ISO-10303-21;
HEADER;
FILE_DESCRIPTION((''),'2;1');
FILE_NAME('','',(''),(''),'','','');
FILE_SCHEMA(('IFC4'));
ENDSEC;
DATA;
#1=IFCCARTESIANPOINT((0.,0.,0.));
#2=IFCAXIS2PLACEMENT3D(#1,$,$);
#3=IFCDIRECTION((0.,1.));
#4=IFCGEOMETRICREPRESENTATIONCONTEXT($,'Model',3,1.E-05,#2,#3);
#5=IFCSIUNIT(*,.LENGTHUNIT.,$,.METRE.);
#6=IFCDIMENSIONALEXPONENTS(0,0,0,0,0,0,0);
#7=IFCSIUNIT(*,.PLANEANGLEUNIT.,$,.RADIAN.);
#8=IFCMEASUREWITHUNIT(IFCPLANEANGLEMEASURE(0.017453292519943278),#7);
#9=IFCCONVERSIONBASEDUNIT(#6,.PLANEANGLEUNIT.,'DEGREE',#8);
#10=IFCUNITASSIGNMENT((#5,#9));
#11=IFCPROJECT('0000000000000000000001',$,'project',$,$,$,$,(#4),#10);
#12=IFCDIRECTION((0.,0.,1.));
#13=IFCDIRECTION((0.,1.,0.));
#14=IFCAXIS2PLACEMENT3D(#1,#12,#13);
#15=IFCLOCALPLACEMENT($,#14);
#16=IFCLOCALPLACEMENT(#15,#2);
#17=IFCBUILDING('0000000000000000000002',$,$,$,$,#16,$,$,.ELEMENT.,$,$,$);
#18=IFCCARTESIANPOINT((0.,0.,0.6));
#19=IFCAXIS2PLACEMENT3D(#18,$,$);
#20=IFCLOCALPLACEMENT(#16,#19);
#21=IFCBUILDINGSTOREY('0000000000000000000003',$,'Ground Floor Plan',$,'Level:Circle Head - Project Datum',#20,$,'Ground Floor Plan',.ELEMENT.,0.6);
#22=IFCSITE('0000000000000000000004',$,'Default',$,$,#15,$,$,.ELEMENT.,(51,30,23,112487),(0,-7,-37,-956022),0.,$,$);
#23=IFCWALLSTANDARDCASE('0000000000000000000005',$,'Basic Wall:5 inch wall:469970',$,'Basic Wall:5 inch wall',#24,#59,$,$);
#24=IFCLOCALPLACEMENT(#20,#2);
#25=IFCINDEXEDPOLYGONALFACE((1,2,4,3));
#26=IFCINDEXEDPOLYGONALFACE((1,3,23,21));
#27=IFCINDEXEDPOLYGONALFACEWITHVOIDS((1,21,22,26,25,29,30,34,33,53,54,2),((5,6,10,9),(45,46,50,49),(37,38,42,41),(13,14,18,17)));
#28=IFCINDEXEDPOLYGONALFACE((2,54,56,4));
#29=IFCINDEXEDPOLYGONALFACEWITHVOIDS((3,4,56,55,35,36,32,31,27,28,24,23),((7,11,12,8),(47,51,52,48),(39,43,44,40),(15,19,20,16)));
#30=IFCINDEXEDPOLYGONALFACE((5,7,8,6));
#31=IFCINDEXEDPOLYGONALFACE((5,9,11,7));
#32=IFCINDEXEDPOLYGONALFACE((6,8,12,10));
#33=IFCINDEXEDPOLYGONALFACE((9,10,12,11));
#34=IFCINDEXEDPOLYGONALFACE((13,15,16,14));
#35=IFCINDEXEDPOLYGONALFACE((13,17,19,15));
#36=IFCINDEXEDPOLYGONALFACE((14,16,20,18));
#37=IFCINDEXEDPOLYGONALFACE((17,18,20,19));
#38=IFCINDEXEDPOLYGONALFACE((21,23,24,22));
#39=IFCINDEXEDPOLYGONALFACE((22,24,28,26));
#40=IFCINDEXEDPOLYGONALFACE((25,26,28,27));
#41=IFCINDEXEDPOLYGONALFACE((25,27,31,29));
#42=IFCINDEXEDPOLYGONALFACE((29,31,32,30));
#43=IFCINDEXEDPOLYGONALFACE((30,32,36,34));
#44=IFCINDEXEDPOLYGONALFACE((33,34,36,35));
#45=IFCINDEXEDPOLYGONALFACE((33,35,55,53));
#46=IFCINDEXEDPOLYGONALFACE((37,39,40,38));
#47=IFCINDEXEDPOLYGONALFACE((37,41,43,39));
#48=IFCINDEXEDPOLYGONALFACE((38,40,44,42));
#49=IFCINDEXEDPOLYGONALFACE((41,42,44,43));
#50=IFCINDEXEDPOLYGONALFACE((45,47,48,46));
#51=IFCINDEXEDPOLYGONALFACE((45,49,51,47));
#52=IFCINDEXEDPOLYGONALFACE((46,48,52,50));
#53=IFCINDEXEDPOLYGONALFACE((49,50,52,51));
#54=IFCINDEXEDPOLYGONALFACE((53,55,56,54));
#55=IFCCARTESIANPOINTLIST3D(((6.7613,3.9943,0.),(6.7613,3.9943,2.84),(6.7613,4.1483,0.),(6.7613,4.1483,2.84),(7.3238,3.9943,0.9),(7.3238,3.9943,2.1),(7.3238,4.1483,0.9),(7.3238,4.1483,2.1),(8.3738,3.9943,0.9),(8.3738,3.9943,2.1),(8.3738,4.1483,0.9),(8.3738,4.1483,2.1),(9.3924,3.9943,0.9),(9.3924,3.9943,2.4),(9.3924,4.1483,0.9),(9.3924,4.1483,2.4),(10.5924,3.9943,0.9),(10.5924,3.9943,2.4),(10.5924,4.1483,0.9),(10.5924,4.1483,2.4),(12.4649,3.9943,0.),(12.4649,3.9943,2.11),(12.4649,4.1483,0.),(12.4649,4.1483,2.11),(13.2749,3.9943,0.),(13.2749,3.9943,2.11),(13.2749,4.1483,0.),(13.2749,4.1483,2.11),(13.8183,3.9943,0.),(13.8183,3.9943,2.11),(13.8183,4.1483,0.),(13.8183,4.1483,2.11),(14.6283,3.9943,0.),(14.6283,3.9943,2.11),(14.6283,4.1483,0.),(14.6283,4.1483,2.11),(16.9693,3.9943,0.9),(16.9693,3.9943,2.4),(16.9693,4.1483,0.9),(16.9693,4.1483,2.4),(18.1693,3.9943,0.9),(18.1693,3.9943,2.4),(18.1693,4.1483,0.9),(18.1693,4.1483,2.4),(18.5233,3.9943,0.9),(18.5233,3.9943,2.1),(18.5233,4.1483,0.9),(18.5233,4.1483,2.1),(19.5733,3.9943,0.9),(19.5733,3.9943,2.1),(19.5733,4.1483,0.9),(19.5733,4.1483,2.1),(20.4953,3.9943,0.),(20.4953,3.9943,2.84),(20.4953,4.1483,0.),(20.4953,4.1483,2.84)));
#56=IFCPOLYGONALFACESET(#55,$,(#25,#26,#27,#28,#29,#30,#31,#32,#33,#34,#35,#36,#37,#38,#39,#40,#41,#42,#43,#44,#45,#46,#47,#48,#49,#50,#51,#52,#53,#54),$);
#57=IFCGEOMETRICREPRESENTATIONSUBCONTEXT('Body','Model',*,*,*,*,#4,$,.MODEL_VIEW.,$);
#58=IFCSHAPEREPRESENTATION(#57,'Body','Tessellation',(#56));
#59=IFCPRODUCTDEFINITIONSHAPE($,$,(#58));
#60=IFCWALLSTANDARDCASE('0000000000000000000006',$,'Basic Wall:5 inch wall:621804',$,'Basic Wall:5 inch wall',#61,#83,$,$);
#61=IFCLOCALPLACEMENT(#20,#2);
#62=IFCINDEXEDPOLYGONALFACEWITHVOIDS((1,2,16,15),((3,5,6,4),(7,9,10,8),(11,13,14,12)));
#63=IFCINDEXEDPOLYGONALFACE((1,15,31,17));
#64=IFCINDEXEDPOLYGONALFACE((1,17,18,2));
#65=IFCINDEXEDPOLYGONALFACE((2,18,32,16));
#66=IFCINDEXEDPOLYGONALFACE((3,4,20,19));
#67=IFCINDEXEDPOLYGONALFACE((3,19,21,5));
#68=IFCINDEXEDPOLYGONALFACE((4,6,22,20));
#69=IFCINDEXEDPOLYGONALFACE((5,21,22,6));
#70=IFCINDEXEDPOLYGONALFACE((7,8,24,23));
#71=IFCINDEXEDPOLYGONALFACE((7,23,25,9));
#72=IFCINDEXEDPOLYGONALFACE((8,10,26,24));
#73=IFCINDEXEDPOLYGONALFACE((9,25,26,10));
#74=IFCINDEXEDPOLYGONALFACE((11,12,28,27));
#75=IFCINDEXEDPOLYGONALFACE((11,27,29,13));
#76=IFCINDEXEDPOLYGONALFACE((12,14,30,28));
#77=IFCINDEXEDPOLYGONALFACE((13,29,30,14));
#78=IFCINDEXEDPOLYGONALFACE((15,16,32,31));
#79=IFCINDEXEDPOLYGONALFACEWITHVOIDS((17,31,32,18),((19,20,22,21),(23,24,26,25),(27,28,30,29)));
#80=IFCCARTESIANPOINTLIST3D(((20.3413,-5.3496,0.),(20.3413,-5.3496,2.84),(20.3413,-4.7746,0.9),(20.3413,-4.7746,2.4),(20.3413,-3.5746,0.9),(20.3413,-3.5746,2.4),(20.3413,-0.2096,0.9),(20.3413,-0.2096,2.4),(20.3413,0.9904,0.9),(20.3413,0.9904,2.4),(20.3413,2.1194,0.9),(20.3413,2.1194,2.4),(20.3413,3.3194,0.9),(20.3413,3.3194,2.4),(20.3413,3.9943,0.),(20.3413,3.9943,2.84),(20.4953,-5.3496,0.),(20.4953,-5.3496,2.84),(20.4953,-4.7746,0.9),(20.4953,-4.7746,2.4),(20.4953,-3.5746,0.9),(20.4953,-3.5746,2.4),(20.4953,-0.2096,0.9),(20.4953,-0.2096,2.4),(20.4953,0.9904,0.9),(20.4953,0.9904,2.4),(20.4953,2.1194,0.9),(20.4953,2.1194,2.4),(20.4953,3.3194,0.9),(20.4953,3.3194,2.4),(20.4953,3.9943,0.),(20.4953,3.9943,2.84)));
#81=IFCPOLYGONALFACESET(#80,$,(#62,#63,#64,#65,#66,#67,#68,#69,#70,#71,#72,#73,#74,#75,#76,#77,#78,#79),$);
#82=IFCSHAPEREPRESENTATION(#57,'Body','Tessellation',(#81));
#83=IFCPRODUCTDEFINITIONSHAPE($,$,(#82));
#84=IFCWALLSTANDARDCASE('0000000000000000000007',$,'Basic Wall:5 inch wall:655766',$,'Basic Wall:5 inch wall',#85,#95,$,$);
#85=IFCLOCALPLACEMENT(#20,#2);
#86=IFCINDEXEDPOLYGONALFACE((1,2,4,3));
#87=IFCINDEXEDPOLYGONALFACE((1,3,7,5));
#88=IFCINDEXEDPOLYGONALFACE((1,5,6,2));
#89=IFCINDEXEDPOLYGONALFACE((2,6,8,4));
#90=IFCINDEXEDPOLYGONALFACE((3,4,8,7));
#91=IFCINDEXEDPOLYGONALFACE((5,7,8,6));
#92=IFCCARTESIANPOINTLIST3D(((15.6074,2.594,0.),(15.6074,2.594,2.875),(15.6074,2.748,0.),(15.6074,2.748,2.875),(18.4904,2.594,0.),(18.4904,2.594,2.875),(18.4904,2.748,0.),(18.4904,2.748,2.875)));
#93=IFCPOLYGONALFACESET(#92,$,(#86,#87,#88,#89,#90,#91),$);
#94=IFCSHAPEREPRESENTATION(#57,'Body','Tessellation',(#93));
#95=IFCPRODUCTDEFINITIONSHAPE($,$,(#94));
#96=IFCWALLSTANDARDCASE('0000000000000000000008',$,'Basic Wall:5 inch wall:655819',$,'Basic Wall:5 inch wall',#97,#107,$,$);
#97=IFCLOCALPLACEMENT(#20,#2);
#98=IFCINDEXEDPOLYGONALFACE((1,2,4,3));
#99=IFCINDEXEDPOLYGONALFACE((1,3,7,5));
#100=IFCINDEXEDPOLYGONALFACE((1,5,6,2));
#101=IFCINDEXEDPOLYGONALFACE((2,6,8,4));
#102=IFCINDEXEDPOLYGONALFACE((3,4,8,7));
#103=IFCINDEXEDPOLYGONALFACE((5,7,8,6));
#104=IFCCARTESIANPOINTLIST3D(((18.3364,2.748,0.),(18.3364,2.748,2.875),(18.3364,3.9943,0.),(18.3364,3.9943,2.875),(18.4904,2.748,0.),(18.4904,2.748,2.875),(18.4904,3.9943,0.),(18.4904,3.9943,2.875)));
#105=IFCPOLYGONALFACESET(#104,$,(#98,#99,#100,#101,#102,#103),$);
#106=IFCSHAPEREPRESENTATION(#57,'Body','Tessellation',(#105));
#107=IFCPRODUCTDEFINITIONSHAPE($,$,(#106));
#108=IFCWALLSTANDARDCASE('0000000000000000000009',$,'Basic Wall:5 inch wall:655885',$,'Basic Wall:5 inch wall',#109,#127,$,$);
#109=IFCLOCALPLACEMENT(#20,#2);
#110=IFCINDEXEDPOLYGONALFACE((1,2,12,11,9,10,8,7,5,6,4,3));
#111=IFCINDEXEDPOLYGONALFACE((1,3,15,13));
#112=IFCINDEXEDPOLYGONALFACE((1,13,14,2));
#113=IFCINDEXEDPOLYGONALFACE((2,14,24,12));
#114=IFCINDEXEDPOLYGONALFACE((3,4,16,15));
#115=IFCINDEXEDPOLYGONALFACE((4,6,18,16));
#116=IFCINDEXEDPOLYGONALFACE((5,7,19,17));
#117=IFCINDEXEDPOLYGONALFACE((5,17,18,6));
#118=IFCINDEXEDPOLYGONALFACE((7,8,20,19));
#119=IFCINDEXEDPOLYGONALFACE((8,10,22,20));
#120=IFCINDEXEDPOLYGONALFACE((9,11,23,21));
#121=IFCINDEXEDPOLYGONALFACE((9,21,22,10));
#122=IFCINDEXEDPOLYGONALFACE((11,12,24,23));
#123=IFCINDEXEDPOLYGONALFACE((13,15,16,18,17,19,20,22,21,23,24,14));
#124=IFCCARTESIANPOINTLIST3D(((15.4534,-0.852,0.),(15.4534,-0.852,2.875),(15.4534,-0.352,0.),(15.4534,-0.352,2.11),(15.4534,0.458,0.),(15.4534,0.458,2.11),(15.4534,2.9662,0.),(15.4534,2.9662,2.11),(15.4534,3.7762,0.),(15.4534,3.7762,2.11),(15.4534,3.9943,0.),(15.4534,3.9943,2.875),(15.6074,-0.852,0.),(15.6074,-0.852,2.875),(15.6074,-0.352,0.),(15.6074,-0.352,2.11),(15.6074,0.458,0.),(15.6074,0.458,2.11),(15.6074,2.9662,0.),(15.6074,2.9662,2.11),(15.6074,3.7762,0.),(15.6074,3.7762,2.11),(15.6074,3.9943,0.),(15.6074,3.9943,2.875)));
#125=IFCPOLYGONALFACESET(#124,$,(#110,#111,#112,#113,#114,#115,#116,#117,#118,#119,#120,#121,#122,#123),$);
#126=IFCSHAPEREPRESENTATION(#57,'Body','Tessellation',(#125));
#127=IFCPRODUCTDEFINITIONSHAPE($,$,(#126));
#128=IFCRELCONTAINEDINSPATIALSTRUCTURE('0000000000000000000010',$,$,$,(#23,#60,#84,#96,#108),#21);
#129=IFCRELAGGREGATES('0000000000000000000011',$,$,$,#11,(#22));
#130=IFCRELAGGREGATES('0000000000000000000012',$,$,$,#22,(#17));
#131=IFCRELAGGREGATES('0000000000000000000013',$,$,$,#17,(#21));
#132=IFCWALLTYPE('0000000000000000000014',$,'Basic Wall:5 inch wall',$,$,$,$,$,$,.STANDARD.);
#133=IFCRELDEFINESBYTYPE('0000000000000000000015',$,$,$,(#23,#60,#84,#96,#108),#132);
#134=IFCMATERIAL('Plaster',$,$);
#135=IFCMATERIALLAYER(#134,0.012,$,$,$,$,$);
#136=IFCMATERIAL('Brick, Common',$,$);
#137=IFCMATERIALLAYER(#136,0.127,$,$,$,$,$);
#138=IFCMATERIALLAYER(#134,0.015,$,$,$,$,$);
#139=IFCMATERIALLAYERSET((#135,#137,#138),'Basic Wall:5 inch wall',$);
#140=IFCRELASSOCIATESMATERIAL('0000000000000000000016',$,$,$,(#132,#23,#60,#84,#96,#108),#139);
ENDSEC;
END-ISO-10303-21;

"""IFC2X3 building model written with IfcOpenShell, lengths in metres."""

from ifc_helpers import new_model, entity, si_unit, converted_unit, direction, frame, frame_2d, origin, place, context, subcontext, project, spatial, polyline, rectangle, extrude, clip, bounded_halfspace, material, layer, layer_set, layer_usage, type_object, element, save


model = new_model("IFC2X3")

# Units and contexts
model_context = context("Model", 3, precision=1e-05, world=origin(), true_north=direction((0.0, 1.0)))
body_context = subcontext(model_context, "Body", "Model", "MODEL_VIEW")
ifc_project = project(units=[si_unit("LENGTHUNIT", "METRE"), converted_unit("PLANEANGLEUNIT", "DEGREE", entity("IfcPlaneAngleMeasure", 0.017453292519943278), si_unit("PLANEANGLEUNIT", "RADIAN"), dimensions=[0, 0, 0, 0, 0, 0, 0])], contexts=[model_context])

# Site, building, storey
site_placement = place(None, frame((0.0, 0.0, 0.0), z_axis=(0.0, 0.0, 1.0), x_axis=(0.0, 1.0, 0.0)))
site = spatial("IfcSite", under=ifc_project, at=site_placement, Name="Default", CompositionType="ELEMENT", RefLatitude=(51, 30, 23, 112487), RefLongitude=(0, -7, -37, -956022), RefElevation=0.0)
building_placement = place(site_placement, origin())
building = spatial("IfcBuilding", under=site, at=building_placement, CompositionType="ELEMENT")
storey_placement = place(building_placement, frame((0.0, 0.0, 0.6)))
storey = spatial("IfcBuildingStorey", under=building, at=storey_placement, Name="Ground Floor Plan", ObjectType="Level:Circle Head - Project Datum", LongName="Ground Floor Plan", CompositionType="ELEMENT", Elevation=0.6)

# Walls, openings
ifc_material_1 = material(Name="Plaster")
ifc_layer_1 = layer(ifc_material_1, 0.012)
ifc_material_2 = material(Name="Brick, Common")
ifc_layer_2 = layer(ifc_material_2, 0.127)
ifc_layer_3 = layer(ifc_material_1, 0.015)
ifc_layer_set = layer_set([ifc_layer_1, ifc_layer_2, ifc_layer_3], Name="Basic Wall:5 inch wall")
ifc_layer_usage_1 = layer_usage(ifc_layer_set, "AXIS2", "NEGATIVE", 0.077)
wall_type = type_object("IfcWallType", Name="Basic Wall:5 inch wall", PredefinedType="STANDARD", material=ifc_layer_set)
wall_1_placement = place(storey_placement, frame((20.4953, 4.0713, 0.0), z_axis=(0.0, 0.0, 1.0), x_axis=(-1.0, 0.0, 0.0)))
wall_1 = element("IfcWallStandardCase", 1, at=wall_1_placement, inside=storey, type_object=wall_type, material=ifc_layer_usage_1, Name="Basic Wall:5 inch wall:469970", ObjectType="Basic Wall:5 inch wall", context=body_context, shape_type="SweptSolid", body=[
    extrude(rectangle(XDim=13.734, YDim=0.154, at=frame_2d((6.867, 0.0), x_axis=(1.0, 0.0))), origin(), (0.0, 0.0, 1.0), 2.84),
])
opening_1_placement = place(wall_1_placement, frame((8.0304, 0.077, 0.0)))
element("IfcOpeningElement", 2, at=opening_1_placement, cuts=wall_1, ObjectType="Opening", context=body_context, shape_type="SweptSolid", body=[
    extrude(rectangle(XDim=2.11, YDim=0.81, at=frame_2d((1.055, 0.405), x_axis=(1.0, 0.0))), frame((0.0, 0.0, 0.0), z_axis=(0.0, -1.0, 0.0), x_axis=(0.0, 0.0, 1.0)), (0.0, 0.0, 1.0), 0.154),
])
opening_2_placement = place(wall_1_placement, frame((6.677, 0.077, 0.0)))
element("IfcOpeningElement", 3, at=opening_2_placement, cuts=wall_1, ObjectType="Opening", context=body_context, shape_type="SweptSolid", body=[
    extrude(rectangle(XDim=2.11, YDim=0.81, at=frame_2d((1.055, 0.405), x_axis=(1.0, 0.0))), frame((0.0, 0.0, 0.0), z_axis=(0.0, -1.0, 0.0), x_axis=(0.0, 0.0, 1.0)), (0.0, 0.0, 1.0), 0.154),
])
opening_3_placement = place(wall_1_placement, frame((13.1715, 0.077, 0.9)))
element("IfcOpeningElement", 4, at=opening_3_placement, cuts=wall_1, ObjectType="Opening", context=body_context, shape_type="SweptSolid", body=[
    extrude(rectangle(XDim=1.2, YDim=1.05, at=frame_2d((0.6, 0.525), x_axis=(-1.0, 0.0))), frame((0.0, 0.0, 0.0), z_axis=(0.0, -1.0, 0.0), x_axis=(0.0, 0.0, 1.0)), (0.0, 0.0, 1.0), 0.154),
])
opening_4_placement = place(wall_1_placement, frame((1.972, 0.077, 0.9)))
element("IfcOpeningElement", 5, at=opening_4_placement, cuts=wall_1, ObjectType="Opening", context=body_context, shape_type="SweptSolid", body=[
    extrude(rectangle(XDim=1.2, YDim=1.05, at=frame_2d((0.6, 0.525), x_axis=(-1.0, 0.0))), frame((0.0, 0.0, 0.0), z_axis=(0.0, -1.0, 0.0), x_axis=(0.0, 0.0, 1.0)), (0.0, 0.0, 1.0), 0.154),
])
opening_5_placement = place(wall_1_placement, frame((11.1029, 0.077, 0.9)))
element("IfcOpeningElement", 6, at=opening_5_placement, cuts=wall_1, ObjectType="Opening", context=body_context, shape_type="SweptSolid", body=[
    extrude(rectangle(XDim=1.5, YDim=1.2, at=frame_2d((0.75, 0.6), x_axis=(-1.0, 0.0))), frame((0.0, 0.0, 0.0), z_axis=(0.0, -1.0, 0.0), x_axis=(0.0, 0.0, 1.0)), (0.0, 0.0, 1.0), 0.154),
])
opening_6_placement = place(wall_1_placement, frame((3.526, 0.077, 0.9)))
element("IfcOpeningElement", 7, at=opening_6_placement, cuts=wall_1, ObjectType="Opening", context=body_context, shape_type="SweptSolid", body=[
    extrude(rectangle(XDim=1.5, YDim=1.2, at=frame_2d((0.75, 0.6), x_axis=(-1.0, 0.0))), frame((0.0, 0.0, 0.0), z_axis=(0.0, -1.0, 0.0), x_axis=(0.0, 0.0, 1.0)), (0.0, 0.0, 1.0), 0.154),
])
ifc_layer_usage_2 = layer_usage(ifc_layer_set, "AXIS2", "NEGATIVE", 0.077)
wall_2_placement = place(storey_placement, frame((20.4183, 3.9943, 0.0), z_axis=(0.0, 0.0, 1.0), x_axis=(0.0, -1.0, 0.0)))
wall_2 = element("IfcWallStandardCase", 8, at=wall_2_placement, inside=storey, type_object=wall_type, material=ifc_layer_usage_2, Name="Basic Wall:5 inch wall:621804", ObjectType="Basic Wall:5 inch wall", context=body_context, shape_type="SweptSolid", body=[
    extrude(rectangle(XDim=9.344, YDim=0.154, at=frame_2d((4.672, 0.0), x_axis=(-1.0, 0.0))), origin(), (0.0, 0.0, 1.0), 2.84),
])
opening_7_placement = place(wall_2_placement, frame((7.569, -0.077, 0.9)))
element("IfcOpeningElement", 9, at=opening_7_placement, cuts=wall_2, ObjectType="Opening", context=body_context, shape_type="SweptSolid", body=[
    extrude(rectangle(XDim=1.5, YDim=1.2, at=frame_2d((0.75, 0.6), x_axis=(-1.0, 0.0))), frame((0.0, 0.0, 0.0), z_axis=(0.0, 1.0, 0.0), x_axis=(0.0, 0.0, 1.0)), (0.0, 0.0, 1.0), 0.154),
])
opening_8_placement = place(wall_2_placement, frame((3.004, -0.077, 0.9)))
element("IfcOpeningElement", 10, at=opening_8_placement, cuts=wall_2, ObjectType="Opening", context=body_context, shape_type="SweptSolid", body=[
    extrude(rectangle(XDim=1.5, YDim=1.2, at=frame_2d((0.75, 0.6), x_axis=(-1.0, 0.0))), frame((0.0, 0.0, 0.0), z_axis=(0.0, 1.0, 0.0), x_axis=(0.0, 0.0, 1.0)), (0.0, 0.0, 1.0), 0.154),
])
opening_9_placement = place(wall_2_placement, frame((0.675, -0.077, 0.9)))
element("IfcOpeningElement", 11, at=opening_9_placement, cuts=wall_2, ObjectType="Opening", context=body_context, shape_type="SweptSolid", body=[
    extrude(rectangle(XDim=1.5, YDim=1.2, at=frame_2d((0.75, 0.6), x_axis=(-1.0, 0.0))), frame((0.0, 0.0, 0.0), z_axis=(0.0, 1.0, 0.0), x_axis=(0.0, 0.0, 1.0)), (0.0, 0.0, 1.0), 0.154),
])

# Walls
ifc_layer_usage_3 = layer_usage(ifc_layer_set, "AXIS2", "NEGATIVE", 0.077)
wall_3_placement = place(storey_placement, frame((15.6074, 2.671, 0.0)))
element("IfcWallStandardCase", 12, at=wall_3_placement, inside=storey, type_object=wall_type, material=ifc_layer_usage_3, Name="Basic Wall:5 inch wall:655766", ObjectType="Basic Wall:5 inch wall", context=body_context, shape_type="Clipping", body=[
    clip(extrude(rectangle(XDim=2.883, YDim=0.154, at=frame_2d((1.4415, 0.0), x_axis=(-1.0, 0.0))), origin(), (0.0, 0.0, 1.0), 2.875), bounded_halfspace(frame((0.0, -0.077, 2.875), z_axis=(0.0, 0.0, -1.0), x_axis=(0.0, -1.0, 0.0)), True, frame((0.0, -0.077, 2.875)), polyline([(0.0, 0.0), (2.883, 0.0), (2.883, 0.154), (2.729, 0.154), (0.0, 0.154), (0.0, 0.0)]))),
])
ifc_layer_usage_4 = layer_usage(ifc_layer_set, "AXIS2", "NEGATIVE", 0.077)
wall_4_placement = place(storey_placement, frame((18.4134, 2.748, 0.0), z_axis=(0.0, 0.0, 1.0), x_axis=(0.0, 1.0, 0.0)))
element("IfcWallStandardCase", 13, at=wall_4_placement, inside=storey, type_object=wall_type, material=ifc_layer_usage_4, Name="Basic Wall:5 inch wall:655819", ObjectType="Basic Wall:5 inch wall", context=body_context, shape_type="Clipping", body=[
    clip(extrude(rectangle(XDim=1.2463, YDim=0.154, at=frame_2d((0.6232, 0.0), x_axis=(-1.0, 0.0))), origin(), (0.0, 0.0, 1.0), 2.875), bounded_halfspace(frame((0.0, -0.077, 2.875), z_axis=(0.0, 0.0, -1.0), x_axis=(-1.0, 0.0, 0.0)), True, frame((0.0, -0.077, 2.875)), polyline([(0.0, 0.0), (1.2463, 0.0), (1.2463, 0.154), (0.0, 0.154), (0.0, 0.0)]))),
])

# Wall, openings
ifc_layer_usage_5 = layer_usage(ifc_layer_set, "AXIS2", "NEGATIVE", 0.077)
wall_5_placement = place(storey_placement, frame((15.5304, 3.9943, 0.0), z_axis=(0.0, 0.0, 1.0), x_axis=(0.0, -1.0, 0.0)))
wall_5 = element("IfcWallStandardCase", 14, at=wall_5_placement, inside=storey, type_object=wall_type, material=ifc_layer_usage_5, Name="Basic Wall:5 inch wall:655885", ObjectType="Basic Wall:5 inch wall", context=body_context, shape_type="Clipping", body=[
    clip(extrude(rectangle(XDim=4.8463, YDim=0.154, at=frame_2d((2.4232, 0.0), x_axis=(1.0, 0.0))), origin(), (0.0, 0.0, 1.0), 2.875), bounded_halfspace(frame((0.0, -0.077, 2.875), z_axis=(0.0, 0.0, -1.0), x_axis=(1.0, 0.0, 0.0)), True, frame((0.0, -0.077, 2.875)), polyline([(0.0, 0.0), (4.8463, 0.0), (4.8463, 0.154), (1.4003, 0.154), (1.2463, 0.154), (0.0, 0.154), (0.0, 0.0)]))),
])
opening_10_placement = place(wall_5_placement, frame((4.3463, 0.077, 0.0)))
element("IfcOpeningElement", 15, at=opening_10_placement, cuts=wall_5, ObjectType="Opening", context=body_context, shape_type="SweptSolid", body=[
    extrude(rectangle(XDim=2.11, YDim=0.81, at=frame_2d((1.055, 0.405), x_axis=(1.0, 0.0))), frame((0.0, 0.0, 0.0), z_axis=(0.0, -1.0, 0.0), x_axis=(0.0, 0.0, 1.0)), (0.0, 0.0, 1.0), 0.154),
])
opening_11_placement = place(wall_5_placement, frame((1.0282, 0.077, 0.0)))
element("IfcOpeningElement", 16, at=opening_11_placement, cuts=wall_5, ObjectType="Opening", context=body_context, shape_type="SweptSolid", body=[
    extrude(rectangle(XDim=2.11, YDim=0.81, at=frame_2d((1.055, 0.405), x_axis=(1.0, 0.0))), frame((0.0, 0.0, 0.0), z_axis=(0.0, -1.0, 0.0), x_axis=(0.0, 0.0, 1.0)), (0.0, 0.0, 1.0), 0.154),
])

save(model, "model.ifc")
